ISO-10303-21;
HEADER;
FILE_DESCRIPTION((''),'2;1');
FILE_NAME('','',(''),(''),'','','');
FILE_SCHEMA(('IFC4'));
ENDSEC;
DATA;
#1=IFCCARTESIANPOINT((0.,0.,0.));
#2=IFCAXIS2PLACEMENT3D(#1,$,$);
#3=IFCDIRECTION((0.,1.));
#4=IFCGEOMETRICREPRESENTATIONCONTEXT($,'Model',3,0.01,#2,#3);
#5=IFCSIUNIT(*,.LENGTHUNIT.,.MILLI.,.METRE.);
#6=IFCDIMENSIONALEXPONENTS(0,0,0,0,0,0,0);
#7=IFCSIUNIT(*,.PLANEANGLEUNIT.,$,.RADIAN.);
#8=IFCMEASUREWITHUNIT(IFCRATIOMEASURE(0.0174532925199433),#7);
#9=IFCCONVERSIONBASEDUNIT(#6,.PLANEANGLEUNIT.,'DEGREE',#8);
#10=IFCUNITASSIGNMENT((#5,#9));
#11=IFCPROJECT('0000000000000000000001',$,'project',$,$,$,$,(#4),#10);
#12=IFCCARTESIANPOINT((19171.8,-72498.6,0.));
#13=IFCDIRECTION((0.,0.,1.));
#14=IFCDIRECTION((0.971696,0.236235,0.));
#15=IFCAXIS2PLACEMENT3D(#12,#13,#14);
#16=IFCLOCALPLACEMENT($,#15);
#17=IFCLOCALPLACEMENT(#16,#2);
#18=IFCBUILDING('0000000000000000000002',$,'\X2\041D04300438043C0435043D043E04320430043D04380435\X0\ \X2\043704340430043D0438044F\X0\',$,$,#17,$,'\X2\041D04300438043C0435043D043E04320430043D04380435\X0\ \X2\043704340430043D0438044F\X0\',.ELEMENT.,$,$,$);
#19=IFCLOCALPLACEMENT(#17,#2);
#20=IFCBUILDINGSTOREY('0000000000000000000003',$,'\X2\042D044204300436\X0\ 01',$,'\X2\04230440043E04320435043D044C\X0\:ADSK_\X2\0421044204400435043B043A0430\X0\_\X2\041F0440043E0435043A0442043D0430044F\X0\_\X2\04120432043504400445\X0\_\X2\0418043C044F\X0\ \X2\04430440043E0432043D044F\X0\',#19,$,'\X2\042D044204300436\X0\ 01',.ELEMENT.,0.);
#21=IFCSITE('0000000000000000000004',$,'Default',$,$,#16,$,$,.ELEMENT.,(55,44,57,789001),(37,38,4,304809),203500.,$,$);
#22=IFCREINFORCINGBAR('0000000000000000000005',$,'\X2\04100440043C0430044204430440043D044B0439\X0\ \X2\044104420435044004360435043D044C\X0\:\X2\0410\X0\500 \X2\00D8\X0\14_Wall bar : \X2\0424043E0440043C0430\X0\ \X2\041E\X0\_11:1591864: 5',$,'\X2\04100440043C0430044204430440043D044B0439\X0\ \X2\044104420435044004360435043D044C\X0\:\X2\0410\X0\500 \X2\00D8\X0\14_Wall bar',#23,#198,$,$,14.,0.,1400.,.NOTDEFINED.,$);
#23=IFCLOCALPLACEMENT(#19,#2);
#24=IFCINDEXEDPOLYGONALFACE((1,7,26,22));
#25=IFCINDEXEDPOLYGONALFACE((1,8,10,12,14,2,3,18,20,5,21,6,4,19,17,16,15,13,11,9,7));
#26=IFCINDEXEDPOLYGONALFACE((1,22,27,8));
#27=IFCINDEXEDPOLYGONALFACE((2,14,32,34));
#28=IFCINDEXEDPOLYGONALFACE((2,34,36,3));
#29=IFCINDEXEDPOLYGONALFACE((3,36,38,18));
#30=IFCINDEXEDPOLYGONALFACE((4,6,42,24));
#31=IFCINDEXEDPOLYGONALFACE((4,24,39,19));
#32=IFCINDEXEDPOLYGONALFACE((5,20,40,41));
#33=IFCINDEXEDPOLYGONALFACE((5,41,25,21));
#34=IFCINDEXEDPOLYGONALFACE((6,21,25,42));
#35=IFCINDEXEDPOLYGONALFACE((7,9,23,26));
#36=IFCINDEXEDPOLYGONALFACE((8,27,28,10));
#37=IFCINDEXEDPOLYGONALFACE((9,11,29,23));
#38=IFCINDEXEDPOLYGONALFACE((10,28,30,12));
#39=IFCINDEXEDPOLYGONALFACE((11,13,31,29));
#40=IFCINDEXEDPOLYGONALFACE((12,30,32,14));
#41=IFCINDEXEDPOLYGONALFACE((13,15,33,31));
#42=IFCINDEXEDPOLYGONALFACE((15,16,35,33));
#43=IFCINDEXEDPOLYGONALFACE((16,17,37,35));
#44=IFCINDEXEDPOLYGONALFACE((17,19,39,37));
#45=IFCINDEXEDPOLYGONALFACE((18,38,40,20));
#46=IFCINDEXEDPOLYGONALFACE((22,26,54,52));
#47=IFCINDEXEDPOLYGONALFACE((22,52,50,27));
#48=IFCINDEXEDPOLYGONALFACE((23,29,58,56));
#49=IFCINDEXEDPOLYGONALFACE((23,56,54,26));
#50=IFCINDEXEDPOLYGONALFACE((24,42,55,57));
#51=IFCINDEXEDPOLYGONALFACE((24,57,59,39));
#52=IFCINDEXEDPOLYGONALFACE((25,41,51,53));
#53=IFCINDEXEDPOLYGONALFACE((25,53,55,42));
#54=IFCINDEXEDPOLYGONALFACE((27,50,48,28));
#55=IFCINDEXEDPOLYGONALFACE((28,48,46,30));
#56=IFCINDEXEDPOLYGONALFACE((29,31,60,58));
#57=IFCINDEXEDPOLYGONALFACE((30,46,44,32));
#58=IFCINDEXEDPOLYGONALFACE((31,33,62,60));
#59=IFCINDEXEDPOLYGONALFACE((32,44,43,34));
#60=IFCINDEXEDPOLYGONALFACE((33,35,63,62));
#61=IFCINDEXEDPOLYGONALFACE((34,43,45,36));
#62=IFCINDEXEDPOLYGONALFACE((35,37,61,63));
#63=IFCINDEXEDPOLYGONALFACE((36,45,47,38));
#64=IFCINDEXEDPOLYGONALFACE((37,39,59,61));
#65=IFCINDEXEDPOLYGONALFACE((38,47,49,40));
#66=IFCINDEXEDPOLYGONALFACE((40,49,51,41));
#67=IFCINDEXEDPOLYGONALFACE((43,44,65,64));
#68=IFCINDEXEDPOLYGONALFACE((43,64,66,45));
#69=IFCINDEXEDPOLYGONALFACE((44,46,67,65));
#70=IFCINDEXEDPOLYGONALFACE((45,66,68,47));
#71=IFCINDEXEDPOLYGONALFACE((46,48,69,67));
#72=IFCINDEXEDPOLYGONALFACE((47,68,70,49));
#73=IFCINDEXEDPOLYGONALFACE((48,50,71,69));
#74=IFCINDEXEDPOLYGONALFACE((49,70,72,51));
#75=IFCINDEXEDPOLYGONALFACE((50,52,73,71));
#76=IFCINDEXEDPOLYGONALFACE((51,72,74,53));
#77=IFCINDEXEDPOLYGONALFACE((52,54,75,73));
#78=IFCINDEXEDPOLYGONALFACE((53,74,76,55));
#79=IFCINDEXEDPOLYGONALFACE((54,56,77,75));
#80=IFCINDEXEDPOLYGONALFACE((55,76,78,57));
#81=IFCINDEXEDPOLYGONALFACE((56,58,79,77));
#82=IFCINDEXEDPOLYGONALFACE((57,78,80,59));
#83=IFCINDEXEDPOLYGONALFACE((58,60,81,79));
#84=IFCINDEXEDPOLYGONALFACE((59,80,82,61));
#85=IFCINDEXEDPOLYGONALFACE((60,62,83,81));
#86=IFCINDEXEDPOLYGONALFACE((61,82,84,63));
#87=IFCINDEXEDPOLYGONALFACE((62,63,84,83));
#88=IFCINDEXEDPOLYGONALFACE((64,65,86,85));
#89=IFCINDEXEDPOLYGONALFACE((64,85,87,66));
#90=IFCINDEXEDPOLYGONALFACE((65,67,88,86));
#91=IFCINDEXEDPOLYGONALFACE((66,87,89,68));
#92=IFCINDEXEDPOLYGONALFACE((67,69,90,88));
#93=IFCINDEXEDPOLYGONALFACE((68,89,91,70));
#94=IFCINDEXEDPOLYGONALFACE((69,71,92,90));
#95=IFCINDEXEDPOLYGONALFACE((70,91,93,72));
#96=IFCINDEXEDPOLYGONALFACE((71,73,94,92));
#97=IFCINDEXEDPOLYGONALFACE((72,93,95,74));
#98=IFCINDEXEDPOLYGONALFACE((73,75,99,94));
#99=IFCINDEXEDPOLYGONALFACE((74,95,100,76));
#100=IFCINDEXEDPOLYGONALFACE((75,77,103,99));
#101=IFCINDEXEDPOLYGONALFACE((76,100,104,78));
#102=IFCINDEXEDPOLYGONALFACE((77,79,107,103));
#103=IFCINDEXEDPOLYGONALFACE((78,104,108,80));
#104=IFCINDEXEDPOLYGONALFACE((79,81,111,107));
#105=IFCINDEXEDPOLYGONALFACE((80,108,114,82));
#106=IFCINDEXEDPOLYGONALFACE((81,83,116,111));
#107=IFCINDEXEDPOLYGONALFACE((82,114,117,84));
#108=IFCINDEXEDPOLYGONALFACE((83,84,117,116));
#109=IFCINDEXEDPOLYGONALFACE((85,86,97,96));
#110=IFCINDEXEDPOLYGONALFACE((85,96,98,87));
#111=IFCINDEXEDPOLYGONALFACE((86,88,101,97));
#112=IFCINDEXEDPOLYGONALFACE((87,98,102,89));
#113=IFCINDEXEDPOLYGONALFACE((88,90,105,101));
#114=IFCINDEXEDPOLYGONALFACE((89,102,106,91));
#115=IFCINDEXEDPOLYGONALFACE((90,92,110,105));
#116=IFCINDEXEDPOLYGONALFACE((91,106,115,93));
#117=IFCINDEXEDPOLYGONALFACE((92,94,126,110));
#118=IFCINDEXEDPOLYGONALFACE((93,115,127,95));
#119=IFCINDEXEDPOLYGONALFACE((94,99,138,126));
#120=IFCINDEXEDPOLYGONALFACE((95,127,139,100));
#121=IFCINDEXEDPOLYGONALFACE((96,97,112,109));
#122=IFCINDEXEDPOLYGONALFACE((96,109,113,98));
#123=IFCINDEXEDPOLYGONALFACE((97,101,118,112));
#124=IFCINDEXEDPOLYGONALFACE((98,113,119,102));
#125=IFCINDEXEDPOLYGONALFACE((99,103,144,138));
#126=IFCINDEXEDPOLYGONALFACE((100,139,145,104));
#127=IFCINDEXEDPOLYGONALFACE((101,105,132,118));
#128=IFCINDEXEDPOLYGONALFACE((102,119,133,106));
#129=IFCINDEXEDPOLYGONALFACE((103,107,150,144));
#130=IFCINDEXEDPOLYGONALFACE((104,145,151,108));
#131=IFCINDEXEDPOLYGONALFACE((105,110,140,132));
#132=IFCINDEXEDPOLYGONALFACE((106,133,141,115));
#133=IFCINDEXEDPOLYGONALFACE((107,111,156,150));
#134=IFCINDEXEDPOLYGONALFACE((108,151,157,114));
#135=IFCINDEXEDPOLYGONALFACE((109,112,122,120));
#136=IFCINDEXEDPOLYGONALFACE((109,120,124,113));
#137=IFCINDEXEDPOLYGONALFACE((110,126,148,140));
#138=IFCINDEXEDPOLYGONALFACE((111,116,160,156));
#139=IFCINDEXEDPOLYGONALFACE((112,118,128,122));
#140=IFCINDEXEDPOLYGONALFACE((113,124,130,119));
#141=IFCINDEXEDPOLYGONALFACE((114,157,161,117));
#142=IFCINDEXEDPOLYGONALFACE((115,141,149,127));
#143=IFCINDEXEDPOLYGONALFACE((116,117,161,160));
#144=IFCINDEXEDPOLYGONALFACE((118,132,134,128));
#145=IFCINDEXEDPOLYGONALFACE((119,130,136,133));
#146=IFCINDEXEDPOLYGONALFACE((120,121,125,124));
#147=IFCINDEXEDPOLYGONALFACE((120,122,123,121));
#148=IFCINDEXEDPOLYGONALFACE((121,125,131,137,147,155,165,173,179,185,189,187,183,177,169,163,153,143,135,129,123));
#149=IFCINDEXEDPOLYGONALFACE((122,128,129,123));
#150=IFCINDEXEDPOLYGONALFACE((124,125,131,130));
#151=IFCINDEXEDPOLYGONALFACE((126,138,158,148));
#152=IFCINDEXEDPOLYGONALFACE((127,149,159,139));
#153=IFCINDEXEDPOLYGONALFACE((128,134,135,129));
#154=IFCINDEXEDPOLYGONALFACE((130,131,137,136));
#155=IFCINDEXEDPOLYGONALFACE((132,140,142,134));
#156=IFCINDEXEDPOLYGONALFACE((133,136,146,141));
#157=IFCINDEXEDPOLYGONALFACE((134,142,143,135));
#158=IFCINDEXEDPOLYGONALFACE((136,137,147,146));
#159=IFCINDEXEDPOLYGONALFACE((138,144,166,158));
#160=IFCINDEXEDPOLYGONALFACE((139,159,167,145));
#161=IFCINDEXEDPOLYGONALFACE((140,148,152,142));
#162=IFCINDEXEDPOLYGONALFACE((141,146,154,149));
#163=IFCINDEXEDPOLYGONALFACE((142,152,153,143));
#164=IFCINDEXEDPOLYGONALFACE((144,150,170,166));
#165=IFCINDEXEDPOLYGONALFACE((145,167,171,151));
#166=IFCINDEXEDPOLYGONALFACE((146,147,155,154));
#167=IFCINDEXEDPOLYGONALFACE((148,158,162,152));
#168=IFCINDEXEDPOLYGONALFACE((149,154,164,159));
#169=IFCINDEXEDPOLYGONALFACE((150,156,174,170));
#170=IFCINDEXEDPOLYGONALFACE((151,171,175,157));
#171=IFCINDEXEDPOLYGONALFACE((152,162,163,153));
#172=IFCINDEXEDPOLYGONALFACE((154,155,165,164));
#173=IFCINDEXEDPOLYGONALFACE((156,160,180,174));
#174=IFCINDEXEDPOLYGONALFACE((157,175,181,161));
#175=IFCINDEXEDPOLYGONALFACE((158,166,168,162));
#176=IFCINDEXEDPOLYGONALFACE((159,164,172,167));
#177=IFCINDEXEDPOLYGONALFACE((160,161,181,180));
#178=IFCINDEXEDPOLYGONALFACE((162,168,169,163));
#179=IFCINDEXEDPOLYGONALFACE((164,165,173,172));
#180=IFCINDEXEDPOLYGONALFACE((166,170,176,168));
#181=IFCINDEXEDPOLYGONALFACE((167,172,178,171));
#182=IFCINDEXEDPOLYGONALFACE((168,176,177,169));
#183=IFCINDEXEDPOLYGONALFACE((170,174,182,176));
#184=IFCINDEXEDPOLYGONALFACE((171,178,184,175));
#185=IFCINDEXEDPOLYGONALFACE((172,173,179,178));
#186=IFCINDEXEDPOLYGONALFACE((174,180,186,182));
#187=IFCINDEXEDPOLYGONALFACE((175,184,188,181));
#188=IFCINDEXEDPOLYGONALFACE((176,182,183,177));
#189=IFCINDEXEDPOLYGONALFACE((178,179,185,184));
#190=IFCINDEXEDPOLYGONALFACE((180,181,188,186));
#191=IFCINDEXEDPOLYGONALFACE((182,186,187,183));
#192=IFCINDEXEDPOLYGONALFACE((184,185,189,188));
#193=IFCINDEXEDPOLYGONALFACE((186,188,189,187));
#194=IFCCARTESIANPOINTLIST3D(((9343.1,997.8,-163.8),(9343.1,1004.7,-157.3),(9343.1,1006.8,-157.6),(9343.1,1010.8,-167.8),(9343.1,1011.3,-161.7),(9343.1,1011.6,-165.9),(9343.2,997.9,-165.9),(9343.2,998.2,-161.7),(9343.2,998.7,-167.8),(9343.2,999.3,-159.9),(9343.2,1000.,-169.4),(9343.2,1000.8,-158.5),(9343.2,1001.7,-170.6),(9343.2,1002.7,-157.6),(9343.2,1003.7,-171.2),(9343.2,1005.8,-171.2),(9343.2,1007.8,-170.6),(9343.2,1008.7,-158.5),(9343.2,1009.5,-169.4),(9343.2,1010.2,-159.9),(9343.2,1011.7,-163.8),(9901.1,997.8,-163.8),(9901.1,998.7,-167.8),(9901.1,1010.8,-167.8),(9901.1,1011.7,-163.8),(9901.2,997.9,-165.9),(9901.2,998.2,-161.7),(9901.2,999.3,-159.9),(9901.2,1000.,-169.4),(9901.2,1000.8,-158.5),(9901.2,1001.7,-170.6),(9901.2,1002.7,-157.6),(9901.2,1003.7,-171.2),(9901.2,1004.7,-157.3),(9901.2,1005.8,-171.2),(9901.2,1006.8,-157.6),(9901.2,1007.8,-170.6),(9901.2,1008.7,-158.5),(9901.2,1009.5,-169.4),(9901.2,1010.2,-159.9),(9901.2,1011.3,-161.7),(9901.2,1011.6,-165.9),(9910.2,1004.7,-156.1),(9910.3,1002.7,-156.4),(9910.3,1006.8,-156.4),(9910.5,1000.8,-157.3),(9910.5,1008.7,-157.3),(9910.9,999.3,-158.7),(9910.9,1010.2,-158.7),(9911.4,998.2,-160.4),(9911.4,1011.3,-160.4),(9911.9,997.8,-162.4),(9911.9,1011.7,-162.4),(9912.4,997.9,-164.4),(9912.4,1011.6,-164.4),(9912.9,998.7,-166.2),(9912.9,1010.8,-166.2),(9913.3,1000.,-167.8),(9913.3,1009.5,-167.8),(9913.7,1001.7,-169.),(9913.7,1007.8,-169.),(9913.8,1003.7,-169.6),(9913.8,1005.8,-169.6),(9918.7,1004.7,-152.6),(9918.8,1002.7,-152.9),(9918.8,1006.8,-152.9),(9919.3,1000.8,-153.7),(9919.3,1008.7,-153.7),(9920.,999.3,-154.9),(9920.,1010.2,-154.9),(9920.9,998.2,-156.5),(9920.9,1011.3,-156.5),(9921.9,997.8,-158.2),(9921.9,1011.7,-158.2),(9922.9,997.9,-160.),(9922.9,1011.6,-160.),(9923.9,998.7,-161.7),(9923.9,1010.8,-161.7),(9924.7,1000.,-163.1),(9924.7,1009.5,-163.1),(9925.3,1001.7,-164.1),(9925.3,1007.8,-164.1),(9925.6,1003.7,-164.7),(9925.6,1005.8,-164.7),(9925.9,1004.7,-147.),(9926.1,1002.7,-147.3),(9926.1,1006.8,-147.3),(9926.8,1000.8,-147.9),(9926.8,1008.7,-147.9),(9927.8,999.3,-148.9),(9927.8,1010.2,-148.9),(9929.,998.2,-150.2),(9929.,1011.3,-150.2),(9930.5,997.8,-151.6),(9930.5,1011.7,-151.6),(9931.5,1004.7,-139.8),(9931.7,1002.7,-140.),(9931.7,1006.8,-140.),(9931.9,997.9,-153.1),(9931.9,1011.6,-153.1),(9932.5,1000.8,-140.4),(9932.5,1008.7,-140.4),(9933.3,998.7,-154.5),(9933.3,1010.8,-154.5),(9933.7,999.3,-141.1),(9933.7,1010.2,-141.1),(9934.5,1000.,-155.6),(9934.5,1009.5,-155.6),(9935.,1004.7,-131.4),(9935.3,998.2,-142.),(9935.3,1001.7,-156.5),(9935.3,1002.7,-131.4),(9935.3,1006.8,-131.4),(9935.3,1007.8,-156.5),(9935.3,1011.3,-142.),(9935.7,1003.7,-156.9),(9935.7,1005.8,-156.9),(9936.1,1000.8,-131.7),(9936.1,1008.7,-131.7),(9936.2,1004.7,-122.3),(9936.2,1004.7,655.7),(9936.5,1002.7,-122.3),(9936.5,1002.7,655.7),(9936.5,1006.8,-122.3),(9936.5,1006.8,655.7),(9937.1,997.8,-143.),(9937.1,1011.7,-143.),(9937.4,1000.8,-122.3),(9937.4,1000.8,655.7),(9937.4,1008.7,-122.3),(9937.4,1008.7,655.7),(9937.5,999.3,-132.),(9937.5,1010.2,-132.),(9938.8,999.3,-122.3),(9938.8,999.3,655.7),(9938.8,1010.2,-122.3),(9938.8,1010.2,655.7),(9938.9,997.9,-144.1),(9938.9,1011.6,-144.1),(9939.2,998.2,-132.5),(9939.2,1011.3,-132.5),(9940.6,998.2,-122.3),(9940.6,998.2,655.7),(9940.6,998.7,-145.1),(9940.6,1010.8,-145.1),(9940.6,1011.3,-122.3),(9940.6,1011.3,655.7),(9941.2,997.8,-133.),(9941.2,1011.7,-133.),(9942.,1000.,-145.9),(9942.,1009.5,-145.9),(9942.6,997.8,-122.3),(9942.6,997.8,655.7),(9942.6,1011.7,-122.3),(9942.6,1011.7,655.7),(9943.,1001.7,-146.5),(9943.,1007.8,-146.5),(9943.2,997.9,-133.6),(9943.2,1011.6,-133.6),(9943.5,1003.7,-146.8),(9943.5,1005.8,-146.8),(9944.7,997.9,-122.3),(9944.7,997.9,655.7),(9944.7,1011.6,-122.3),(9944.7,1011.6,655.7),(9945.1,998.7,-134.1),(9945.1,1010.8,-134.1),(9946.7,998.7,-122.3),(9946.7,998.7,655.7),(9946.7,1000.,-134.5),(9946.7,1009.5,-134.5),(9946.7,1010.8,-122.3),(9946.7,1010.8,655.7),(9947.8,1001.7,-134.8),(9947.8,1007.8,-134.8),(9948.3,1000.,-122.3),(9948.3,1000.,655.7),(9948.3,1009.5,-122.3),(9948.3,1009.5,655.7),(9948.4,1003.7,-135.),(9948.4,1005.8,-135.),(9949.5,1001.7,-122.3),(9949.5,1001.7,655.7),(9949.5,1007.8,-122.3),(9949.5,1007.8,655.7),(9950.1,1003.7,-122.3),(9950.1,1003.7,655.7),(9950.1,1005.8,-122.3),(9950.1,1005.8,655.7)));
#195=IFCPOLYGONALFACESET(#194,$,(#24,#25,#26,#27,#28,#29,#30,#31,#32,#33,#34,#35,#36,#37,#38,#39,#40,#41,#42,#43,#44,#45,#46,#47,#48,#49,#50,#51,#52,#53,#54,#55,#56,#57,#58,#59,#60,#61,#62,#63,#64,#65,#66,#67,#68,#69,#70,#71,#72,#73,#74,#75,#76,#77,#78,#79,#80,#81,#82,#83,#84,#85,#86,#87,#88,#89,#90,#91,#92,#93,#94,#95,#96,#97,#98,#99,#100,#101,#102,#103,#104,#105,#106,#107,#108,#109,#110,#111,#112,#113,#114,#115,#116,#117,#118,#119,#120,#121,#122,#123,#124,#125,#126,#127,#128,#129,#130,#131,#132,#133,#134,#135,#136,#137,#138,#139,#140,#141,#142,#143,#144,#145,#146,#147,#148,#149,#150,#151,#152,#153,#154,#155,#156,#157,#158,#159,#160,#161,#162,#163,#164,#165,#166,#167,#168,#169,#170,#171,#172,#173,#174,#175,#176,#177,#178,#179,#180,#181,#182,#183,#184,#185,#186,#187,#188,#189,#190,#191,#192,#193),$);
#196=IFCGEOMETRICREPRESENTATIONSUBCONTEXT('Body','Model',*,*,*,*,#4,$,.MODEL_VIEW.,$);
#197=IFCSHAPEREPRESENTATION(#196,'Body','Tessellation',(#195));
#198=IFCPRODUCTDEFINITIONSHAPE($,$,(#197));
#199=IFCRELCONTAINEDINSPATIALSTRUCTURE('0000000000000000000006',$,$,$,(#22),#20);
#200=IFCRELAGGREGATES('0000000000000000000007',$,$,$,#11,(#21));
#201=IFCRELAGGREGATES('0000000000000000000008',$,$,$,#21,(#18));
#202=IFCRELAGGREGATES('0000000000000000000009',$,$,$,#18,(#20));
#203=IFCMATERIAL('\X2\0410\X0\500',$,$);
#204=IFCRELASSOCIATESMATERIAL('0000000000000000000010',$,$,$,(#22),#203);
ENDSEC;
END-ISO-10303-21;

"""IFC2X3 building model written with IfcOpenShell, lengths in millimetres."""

from ifc_helpers import new_model, entity, si_unit, converted_unit, direction, frame, origin, place, context, subcontext, project, spatial, material, element, save


model = new_model("IFC2X3")

# Units and contexts
model_context = context("Model", 3, precision=0.01, world=origin(), true_north=direction((0.0, 1.0)))
body_context = subcontext(model_context, "Body", "Model", "MODEL_VIEW")
ifc_project = project(units=[si_unit("LENGTHUNIT", "METRE", prefix="MILLI"), converted_unit("PLANEANGLEUNIT", "DEGREE", entity("IfcRatioMeasure", 0.0174532925199433), si_unit("PLANEANGLEUNIT", "RADIAN"), dimensions=[0, 0, 0, 0, 0, 0, 0])], contexts=[model_context])

# Site, building, storey
site_placement = place(None, frame((19171.8, -72498.6, 0.0), z_axis=(0.0, 0.0, 1.0), x_axis=(0.971696, 0.236235, 0.0)))
site = spatial("IfcSite", under=ifc_project, at=site_placement, Name="Default", CompositionType="ELEMENT", RefLatitude=(55, 44, 57, 789001), RefLongitude=(37, 38, 4, 304809), RefElevation=203500.0)
building_placement = place(site_placement, origin())
building = spatial("IfcBuilding", under=site, at=building_placement, Name="Наименование здания", LongName="Наименование здания", CompositionType="ELEMENT")
storey_placement = place(building_placement, origin())
storey = spatial("IfcBuildingStorey", under=building, at=storey_placement, Name="Этаж 01", ObjectType="Уровень:ADSK_Стрелка_Проектная_Вверх_Имя уровня", LongName="Этаж 01", CompositionType="ELEMENT", Elevation=0.0)

# Reinforcing bar
ifc_material = material(Name="А500")
placement = place(storey_placement, origin())
element("IfcReinforcingBar", 1, at=placement, inside=storey, material=ifc_material, Name="Арматурный стержень:А500 Ø14_Wall bar : Форма О_11:1591864: 5", ObjectType="Арматурный стержень:А500 Ø14_Wall bar", BarLength=1400.0, BarRole="NOTDEFINED", CrossSectionArea=0.0, NominalDiameter=14.0, context=body_context, shape_type="AdvancedSweptSolid", body=[
    entity("IfcSweptDiskSolid", entity("IfcCompositeCurve", [entity("IfcCompositeCurveSegment", "CONTINUOUS", True, entity("IfcPolyline", [entity("IfcCartesianPoint", [9943.1, 1004.7, 655.7]), entity("IfcCartesianPoint", [9943.1, 1004.7, -122.3])])), entity("IfcCompositeCurveSegment", "CONTINUOUS", True, entity("IfcTrimmedCurve", entity("IfcCircle", entity("IfcAxis2Placement3D", entity("IfcCartesianPoint", [9901.1, 1004.7, -122.3]), entity("IfcDirection", [0.0, 1.0, 0.0]), entity("IfcDirection", [0.0, 0.0, -1.0])), 42.0), [entity("IfcParameterValue", 270.0)], [entity("IfcParameterValue", 360.0)], True, "PARAMETER")), entity("IfcCompositeCurveSegment", "CONTINUOUS", True, entity("IfcPolyline", [entity("IfcCartesianPoint", [9901.1, 1004.7, -164.3]), entity("IfcCartesianPoint", [9343.1, 1004.7, -164.3])]))], False), 7.0, None, 0.0, 92.0),
])

save(model, "model.ifc")
